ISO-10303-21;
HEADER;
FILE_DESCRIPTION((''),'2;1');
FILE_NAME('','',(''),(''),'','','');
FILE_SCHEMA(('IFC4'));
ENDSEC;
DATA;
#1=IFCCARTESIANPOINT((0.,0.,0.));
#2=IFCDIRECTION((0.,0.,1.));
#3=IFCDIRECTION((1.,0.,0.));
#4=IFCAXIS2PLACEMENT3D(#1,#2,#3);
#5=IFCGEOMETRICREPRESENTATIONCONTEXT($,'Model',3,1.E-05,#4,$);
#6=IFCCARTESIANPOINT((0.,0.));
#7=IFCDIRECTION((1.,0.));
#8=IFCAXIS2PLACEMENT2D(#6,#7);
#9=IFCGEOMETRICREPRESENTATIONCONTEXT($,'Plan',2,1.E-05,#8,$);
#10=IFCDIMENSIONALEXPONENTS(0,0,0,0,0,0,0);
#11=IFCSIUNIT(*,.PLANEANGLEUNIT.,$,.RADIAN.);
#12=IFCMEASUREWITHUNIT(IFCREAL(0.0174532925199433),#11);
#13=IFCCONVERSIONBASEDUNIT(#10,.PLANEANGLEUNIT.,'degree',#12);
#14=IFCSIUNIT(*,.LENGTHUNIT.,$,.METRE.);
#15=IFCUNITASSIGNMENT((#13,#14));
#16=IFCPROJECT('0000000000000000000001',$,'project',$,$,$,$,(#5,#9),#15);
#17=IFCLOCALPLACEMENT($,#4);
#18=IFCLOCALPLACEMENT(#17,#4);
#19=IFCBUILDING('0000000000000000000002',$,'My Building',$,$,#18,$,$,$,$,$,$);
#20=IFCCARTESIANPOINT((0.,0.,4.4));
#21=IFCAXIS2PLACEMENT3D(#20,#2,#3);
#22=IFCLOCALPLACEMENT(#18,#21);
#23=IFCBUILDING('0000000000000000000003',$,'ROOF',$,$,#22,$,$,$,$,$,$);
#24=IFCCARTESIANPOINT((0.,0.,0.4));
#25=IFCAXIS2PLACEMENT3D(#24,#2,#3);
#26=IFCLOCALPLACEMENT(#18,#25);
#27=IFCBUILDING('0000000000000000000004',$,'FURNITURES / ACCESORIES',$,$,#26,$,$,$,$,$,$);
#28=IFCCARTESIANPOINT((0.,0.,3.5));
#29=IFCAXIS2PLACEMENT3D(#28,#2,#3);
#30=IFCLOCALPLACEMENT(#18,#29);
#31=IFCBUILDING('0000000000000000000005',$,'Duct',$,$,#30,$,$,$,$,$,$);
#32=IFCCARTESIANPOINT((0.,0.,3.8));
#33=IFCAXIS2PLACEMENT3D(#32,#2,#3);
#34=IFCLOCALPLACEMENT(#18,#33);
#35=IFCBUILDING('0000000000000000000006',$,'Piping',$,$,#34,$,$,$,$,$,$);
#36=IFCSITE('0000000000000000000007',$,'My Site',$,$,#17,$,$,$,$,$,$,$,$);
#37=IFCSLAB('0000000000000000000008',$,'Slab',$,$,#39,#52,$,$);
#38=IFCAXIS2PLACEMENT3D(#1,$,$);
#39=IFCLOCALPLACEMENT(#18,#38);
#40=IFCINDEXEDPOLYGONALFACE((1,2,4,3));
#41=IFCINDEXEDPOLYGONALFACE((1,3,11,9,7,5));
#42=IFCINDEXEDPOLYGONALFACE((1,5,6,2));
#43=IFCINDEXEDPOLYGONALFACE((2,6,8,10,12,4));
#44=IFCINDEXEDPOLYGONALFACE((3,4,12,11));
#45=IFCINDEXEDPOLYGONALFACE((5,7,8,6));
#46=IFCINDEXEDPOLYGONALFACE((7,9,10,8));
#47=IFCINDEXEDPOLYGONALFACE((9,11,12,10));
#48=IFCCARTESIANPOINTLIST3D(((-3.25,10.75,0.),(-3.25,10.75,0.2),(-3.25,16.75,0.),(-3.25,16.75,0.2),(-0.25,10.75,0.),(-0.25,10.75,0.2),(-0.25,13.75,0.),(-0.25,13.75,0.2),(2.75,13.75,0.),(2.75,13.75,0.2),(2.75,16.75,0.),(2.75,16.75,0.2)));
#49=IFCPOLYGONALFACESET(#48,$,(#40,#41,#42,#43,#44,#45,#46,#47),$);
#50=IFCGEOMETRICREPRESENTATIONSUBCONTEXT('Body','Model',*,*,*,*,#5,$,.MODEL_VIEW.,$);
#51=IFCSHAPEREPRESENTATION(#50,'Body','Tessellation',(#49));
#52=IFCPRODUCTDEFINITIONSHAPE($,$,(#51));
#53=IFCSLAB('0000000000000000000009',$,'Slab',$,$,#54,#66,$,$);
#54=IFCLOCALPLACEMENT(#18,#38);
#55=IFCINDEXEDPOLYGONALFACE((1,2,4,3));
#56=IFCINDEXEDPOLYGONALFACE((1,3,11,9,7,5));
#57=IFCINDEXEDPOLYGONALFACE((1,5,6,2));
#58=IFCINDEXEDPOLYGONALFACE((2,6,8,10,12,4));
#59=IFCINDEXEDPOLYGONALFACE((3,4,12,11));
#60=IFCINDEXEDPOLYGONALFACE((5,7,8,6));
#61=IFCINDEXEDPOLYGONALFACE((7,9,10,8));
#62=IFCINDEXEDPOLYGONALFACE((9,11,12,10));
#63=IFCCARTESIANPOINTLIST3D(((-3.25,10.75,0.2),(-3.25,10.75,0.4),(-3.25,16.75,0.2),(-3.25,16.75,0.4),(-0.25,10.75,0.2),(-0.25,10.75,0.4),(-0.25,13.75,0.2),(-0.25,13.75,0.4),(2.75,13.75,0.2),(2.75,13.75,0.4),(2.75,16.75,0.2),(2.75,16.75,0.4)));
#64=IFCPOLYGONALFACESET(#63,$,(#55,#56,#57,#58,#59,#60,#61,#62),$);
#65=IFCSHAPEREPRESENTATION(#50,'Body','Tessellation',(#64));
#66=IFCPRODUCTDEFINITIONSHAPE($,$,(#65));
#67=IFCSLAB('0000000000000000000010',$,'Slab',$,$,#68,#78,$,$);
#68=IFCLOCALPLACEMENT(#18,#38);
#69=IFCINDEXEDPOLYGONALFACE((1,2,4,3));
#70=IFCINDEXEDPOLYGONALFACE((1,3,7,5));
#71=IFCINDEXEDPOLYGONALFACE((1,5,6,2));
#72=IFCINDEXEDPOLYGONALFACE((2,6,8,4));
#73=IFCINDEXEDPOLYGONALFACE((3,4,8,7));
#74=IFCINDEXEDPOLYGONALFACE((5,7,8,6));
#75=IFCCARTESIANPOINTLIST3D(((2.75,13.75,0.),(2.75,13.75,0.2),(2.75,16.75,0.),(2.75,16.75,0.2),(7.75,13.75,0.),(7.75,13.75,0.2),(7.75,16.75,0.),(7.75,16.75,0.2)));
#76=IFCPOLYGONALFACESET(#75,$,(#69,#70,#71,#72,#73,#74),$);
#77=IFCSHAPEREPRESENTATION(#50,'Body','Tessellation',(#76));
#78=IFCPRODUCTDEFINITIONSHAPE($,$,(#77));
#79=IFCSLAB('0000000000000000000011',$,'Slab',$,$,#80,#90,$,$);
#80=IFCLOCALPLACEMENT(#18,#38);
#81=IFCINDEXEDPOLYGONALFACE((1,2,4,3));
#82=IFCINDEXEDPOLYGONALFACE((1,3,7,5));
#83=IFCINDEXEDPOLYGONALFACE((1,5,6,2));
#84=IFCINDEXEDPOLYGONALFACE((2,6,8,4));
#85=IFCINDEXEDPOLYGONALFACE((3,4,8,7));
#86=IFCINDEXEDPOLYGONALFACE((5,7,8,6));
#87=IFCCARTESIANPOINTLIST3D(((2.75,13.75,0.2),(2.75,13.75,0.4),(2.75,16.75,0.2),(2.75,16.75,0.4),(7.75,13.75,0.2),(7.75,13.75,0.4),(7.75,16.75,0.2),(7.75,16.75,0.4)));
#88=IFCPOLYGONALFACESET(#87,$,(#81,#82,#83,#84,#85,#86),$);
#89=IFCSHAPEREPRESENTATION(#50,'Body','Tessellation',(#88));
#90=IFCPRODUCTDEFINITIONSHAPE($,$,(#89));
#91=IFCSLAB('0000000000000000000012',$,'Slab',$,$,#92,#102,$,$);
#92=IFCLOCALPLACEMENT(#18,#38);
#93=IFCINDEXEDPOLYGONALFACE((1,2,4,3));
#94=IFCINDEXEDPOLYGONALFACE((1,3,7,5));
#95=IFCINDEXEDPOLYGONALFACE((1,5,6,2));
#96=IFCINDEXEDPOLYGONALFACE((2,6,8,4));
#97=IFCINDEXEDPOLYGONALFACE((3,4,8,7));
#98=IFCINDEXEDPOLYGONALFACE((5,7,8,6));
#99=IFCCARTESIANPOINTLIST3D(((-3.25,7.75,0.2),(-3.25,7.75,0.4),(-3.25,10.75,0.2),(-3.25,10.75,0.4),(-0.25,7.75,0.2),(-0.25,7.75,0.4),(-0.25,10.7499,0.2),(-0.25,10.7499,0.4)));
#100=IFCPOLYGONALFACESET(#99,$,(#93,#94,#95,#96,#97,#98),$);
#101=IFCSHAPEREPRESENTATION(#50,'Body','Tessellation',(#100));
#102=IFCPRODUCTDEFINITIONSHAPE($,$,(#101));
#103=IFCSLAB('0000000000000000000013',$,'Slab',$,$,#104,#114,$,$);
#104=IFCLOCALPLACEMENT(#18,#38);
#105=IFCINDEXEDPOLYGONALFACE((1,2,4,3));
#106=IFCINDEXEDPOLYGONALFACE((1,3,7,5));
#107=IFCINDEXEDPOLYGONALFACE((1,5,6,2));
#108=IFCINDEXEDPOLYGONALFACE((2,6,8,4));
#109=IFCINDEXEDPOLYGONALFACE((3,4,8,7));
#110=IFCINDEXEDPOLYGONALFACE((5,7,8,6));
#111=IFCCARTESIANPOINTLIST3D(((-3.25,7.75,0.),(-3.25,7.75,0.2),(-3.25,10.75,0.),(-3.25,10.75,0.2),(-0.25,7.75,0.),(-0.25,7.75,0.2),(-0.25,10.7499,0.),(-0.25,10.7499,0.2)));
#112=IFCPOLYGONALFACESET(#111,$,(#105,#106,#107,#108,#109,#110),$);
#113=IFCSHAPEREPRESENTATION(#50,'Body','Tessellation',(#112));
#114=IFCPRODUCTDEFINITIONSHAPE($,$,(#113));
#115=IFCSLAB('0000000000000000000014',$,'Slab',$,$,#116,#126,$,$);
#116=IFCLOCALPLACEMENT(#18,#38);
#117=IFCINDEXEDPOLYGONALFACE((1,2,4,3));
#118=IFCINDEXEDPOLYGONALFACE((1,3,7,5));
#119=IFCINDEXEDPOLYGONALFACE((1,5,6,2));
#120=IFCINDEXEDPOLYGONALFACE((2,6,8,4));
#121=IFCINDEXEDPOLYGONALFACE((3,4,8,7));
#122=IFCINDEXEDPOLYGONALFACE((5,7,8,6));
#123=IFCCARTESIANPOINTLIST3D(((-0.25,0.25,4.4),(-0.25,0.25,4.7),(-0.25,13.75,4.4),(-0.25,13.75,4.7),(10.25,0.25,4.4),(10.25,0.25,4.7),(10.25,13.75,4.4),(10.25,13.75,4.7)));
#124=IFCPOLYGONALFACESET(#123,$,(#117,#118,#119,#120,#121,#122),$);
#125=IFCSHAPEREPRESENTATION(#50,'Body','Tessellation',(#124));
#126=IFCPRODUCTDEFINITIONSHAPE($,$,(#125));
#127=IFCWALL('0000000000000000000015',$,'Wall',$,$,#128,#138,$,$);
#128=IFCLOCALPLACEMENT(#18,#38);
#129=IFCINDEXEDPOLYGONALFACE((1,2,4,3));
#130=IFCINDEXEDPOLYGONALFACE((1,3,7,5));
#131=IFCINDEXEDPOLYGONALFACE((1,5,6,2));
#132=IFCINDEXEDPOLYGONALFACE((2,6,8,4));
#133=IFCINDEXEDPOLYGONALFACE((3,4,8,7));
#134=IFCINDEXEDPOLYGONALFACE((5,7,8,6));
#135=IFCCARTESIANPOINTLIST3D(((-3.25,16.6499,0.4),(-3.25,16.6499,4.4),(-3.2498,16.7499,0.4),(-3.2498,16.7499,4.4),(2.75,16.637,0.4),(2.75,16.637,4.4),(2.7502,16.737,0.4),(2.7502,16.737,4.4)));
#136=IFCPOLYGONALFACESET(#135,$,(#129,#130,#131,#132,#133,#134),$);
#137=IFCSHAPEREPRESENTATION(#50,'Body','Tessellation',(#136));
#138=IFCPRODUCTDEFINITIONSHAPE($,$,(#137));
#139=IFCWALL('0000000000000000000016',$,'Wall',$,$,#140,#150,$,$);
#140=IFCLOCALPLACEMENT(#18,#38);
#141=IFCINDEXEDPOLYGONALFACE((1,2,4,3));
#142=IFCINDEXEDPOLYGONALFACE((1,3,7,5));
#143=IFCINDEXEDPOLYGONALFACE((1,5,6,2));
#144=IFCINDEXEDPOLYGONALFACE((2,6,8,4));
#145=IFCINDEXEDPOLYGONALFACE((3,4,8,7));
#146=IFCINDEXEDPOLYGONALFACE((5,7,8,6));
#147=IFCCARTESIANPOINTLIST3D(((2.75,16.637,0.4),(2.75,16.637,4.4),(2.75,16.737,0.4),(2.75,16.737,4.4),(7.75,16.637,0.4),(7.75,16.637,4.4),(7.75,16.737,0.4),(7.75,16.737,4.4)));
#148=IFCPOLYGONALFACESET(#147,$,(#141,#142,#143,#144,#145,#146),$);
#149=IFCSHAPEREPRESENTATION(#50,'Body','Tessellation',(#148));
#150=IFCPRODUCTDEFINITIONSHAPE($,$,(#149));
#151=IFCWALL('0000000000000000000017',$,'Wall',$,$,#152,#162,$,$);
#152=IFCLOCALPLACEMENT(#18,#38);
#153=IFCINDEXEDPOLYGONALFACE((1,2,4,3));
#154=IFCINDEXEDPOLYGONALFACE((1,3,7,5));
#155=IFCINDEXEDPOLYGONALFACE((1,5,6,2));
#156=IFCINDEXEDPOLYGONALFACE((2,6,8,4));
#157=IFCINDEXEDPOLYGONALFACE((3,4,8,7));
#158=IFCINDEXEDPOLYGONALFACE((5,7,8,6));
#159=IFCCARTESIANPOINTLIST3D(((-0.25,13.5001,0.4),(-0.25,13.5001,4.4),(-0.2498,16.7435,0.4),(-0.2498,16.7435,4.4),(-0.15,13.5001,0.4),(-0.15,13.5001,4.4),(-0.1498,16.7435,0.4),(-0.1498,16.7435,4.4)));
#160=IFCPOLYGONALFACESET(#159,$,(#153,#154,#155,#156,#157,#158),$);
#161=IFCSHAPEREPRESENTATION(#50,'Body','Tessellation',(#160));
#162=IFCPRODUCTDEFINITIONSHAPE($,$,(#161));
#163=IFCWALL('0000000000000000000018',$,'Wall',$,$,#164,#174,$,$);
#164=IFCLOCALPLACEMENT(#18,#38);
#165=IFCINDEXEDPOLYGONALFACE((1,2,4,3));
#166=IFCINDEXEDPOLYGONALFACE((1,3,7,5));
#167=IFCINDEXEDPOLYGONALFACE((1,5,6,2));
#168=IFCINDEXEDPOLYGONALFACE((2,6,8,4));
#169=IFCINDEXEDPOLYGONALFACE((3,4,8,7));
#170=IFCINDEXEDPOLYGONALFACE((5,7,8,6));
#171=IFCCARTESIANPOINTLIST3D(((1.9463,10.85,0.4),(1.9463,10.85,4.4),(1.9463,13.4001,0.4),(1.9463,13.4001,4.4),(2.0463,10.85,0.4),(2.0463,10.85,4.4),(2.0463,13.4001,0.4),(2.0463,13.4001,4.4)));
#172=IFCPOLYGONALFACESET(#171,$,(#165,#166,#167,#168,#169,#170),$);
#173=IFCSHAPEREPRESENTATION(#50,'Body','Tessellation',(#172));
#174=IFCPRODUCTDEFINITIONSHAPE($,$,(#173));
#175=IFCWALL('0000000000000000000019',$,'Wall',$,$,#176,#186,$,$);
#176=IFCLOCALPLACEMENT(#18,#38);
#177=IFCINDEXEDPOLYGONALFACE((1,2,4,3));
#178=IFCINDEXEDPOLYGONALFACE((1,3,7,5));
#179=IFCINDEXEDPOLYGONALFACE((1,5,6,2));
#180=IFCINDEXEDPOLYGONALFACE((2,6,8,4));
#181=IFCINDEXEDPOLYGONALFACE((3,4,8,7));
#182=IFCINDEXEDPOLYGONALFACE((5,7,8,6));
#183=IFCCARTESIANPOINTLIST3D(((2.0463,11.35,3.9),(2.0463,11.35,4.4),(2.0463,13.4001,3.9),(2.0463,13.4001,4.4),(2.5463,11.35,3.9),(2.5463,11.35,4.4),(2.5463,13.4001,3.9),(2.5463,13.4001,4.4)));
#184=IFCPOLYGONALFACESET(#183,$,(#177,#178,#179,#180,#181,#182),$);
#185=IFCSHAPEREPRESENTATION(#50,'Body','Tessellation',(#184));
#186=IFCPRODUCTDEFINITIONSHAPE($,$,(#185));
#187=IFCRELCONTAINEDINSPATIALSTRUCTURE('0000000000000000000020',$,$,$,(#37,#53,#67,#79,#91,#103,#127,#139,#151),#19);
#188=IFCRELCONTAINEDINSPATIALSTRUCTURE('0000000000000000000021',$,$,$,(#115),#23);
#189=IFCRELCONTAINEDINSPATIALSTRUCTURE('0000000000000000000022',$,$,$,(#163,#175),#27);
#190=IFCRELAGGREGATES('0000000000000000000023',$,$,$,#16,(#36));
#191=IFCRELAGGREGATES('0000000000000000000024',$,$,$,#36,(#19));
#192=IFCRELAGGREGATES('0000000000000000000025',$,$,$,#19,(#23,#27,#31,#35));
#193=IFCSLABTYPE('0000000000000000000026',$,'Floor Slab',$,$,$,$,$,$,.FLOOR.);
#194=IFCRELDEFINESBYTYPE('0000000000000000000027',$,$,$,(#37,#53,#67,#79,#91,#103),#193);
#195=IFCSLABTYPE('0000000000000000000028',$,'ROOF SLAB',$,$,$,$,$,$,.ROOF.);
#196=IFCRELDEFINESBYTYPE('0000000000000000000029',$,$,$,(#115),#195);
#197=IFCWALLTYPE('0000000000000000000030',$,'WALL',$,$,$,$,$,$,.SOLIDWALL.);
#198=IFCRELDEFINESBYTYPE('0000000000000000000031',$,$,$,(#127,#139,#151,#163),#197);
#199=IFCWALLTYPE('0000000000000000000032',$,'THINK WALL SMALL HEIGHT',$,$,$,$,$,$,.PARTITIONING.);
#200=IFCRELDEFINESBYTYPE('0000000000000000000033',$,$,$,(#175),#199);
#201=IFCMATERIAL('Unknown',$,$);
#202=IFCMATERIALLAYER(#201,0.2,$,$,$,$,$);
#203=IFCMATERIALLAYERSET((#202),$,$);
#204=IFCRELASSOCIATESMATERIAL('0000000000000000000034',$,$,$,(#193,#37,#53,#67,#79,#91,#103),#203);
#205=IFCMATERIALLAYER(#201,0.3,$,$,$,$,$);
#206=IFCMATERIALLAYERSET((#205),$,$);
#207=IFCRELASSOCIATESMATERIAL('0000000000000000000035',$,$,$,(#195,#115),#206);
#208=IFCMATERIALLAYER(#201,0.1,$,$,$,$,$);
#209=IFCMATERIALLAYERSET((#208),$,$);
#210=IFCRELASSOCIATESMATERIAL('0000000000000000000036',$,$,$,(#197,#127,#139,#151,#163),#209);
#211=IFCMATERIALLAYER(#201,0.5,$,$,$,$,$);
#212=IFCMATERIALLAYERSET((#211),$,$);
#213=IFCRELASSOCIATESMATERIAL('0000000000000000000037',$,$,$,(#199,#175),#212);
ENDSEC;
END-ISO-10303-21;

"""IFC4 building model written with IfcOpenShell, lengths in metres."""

from ifc_helpers import new_model, entity, si_unit, converted_unit, frame, origin_with_axes, origin_2d_with_axis, place, context, subcontext, project, spatial, line, indexed_curve, outline, extrude, material, layer, layer_set, layer_usage, type_object, element, save


model = new_model("IFC4")

# Units and contexts
model_context = context("Model", 3, precision=1e-05, world=origin_with_axes())
plan_context = context("Plan", 2, precision=1e-05, world=origin_2d_with_axis())
body_context_1 = subcontext(model_context, "Body", "Model", "MODEL_VIEW")
ifc_project = project(units=[converted_unit("PLANEANGLEUNIT", "degree", entity("IfcReal", 0.0174532925199433), si_unit("PLANEANGLEUNIT", "RADIAN"), dimensions=[0, 0, 0, 0, 0, 0, 0]), si_unit("LENGTHUNIT", "METRE")], contexts=[model_context, plan_context])

# Site, building
site_placement = place(None, origin_with_axes())
site = spatial("IfcSite", under=ifc_project, at=site_placement, Name="My Site")
building_1_placement = place(site_placement, origin_with_axes())
building_1 = spatial("IfcBuilding", under=site, at=building_1_placement, Name="My Building")

# Slabs
ifc_material = material(Name="Unknown")
ifc_layer_1 = layer(ifc_material, 0.2)
ifc_layer_set_1 = layer_set([ifc_layer_1])
ifc_layer_usage_1 = layer_usage(ifc_layer_set_1, "AXIS3", "POSITIVE", 0.0)
slab_type_1 = type_object("IfcSlabType", Name="Floor Slab", PredefinedType="FLOOR", material=ifc_layer_set_1)
slab_1_placement = place(building_1_placement, frame((-0.25, 13.75, 0.0), z_axis=(0.0, 0.0, 1.0), x_axis=(1.0, 0.0, 0.0)))
element("IfcSlab", 1, at=slab_1_placement, inside=building_1, type_object=slab_type_1, material=ifc_layer_usage_1, Name="Slab", context=body_context_1, shape_type="SweptSolid", body=[
    extrude(outline(indexed_curve([(0.0, 0.0), (3.0, 0.0), (3.0, 3.0), (-3.0, 3.0), (-3.0, -3.0), (0.0, -3.0), (0.0, 0.0)])), None, (0.0, 0.0, 1.0), 0.2),
])
ifc_layer_usage_2 = layer_usage(ifc_layer_set_1, "AXIS3", "POSITIVE", 0.0)
slab_2_placement = place(building_1_placement, frame((-0.25, 13.75, 0.2), z_axis=(0.0, 0.0, 1.0), x_axis=(1.0, 0.0, 0.0)))
element("IfcSlab", 2, at=slab_2_placement, inside=building_1, type_object=slab_type_1, material=ifc_layer_usage_2, Name="Slab", context=body_context_1, shape_type="SweptSolid", body=[
    extrude(outline(indexed_curve([(0.0, 0.0), (3.0, 0.0), (3.0, 3.0), (-3.0, 3.0), (-3.0, -3.0), (0.0, -3.0), (0.0, 0.0)])), None, (0.0, 0.0, 1.0), 0.2),
])
ifc_layer_usage_3 = layer_usage(ifc_layer_set_1, "AXIS3", "POSITIVE", 0.0)
slab_3_placement = place(building_1_placement, frame((2.75, 16.75, 0.0), z_axis=(0.0, 0.0, 1.0), x_axis=(1.0, 0.0, 0.0)))
element("IfcSlab", 3, at=slab_3_placement, inside=building_1, type_object=slab_type_1, material=ifc_layer_usage_3, Name="Slab", context=body_context_1, shape_type="SweptSolid", body=[
    extrude(outline(indexed_curve([(0.0, 0.0), (5.0, 0.0), (5.0, -3.0), (0.0, -3.0), (0.0, 0.0)])), None, (0.0, 0.0, 1.0), 0.2),
])
ifc_layer_usage_4 = layer_usage(ifc_layer_set_1, "AXIS3", "POSITIVE", 0.0)
slab_4_placement = place(building_1_placement, frame((2.75, 16.75, 0.2), z_axis=(0.0, 0.0, 1.0), x_axis=(1.0, 0.0, 0.0)))
element("IfcSlab", 4, at=slab_4_placement, inside=building_1, type_object=slab_type_1, material=ifc_layer_usage_4, Name="Slab", context=body_context_1, shape_type="SweptSolid", body=[
    extrude(outline(indexed_curve([(0.0, 0.0), (5.0, 0.0), (5.0, -3.0), (0.0, -3.0), (0.0, 0.0)])), None, (0.0, 0.0, 1.0), 0.2),
])
ifc_layer_usage_5 = layer_usage(ifc_layer_set_1, "AXIS3", "POSITIVE", -0.2)
slab_5_placement = place(building_1_placement, frame((-3.25, 10.75, 0.4), z_axis=(0.0, 0.0, 1.0), x_axis=(1.0, 0.0, 0.0)))
element("IfcSlab", 5, at=slab_5_placement, inside=building_1, type_object=slab_type_1, material=ifc_layer_usage_5, Name="Slab", context=body_context_1, shape_type="SweptSolid", body=[
    extrude(outline(indexed_curve([(0.0, 0.0), (0.0, -3.0), (3.0, -3.0), (3.0, -0.0001), (0.0, 0.0)])), frame((0.0, 0.0, -0.2), z_axis=(0.0, 0.0, 1.0), x_axis=(1.0, 0.0, 0.0)), (0.0, 0.0, 1.0), 0.2),
])
ifc_layer_usage_6 = layer_usage(ifc_layer_set_1, "AXIS3", "POSITIVE", -0.2)
slab_6_placement = place(building_1_placement, frame((-3.25, 10.75, 0.2), z_axis=(0.0, 0.0, 1.0), x_axis=(1.0, 0.0, 0.0)))
element("IfcSlab", 6, at=slab_6_placement, inside=building_1, type_object=slab_type_1, material=ifc_layer_usage_6, Name="Slab", context=body_context_1, shape_type="SweptSolid", body=[
    extrude(outline(indexed_curve([(0.0, 0.0), (0.0, -3.0), (3.0, -3.0), (3.0, -0.0001), (0.0, 0.0)])), frame((0.0, 0.0, -0.2), z_axis=(0.0, 0.0, 1.0), x_axis=(1.0, 0.0, 0.0)), (0.0, 0.0, 1.0), 0.2),
])

# Shared definitions
building_2_placement = place(building_1_placement, frame((0.0, 0.0, 4.4), z_axis=(0.0, 0.0, 1.0), x_axis=(1.0, 0.0, 0.0)))
building_2 = spatial("IfcBuilding", under=building_1, at=building_2_placement, Name="ROOF")

# Slab
ifc_layer_2 = layer(ifc_material, 0.3)
ifc_layer_set_2 = layer_set([ifc_layer_2])
ifc_layer_usage_7 = layer_usage(ifc_layer_set_2, "AXIS3", "POSITIVE", 0.0)
slab_type_2 = type_object("IfcSlabType", Name="ROOF SLAB", PredefinedType="ROOF", material=ifc_layer_set_2)
slab_7_placement = place(building_2_placement, frame((-0.25, 13.75, 0.0), z_axis=(0.0, 0.0, 1.0), x_axis=(1.0, 0.0, 0.0)))
element("IfcSlab", 7, at=slab_7_placement, inside=building_2, type_object=slab_type_2, material=ifc_layer_usage_7, Name="Slab", context=body_context_1, shape_type="SweptSolid", body=[
    extrude(outline(indexed_curve([(0.0, 0.0), (10.5, 0.0), (10.5, -13.5), (0.0, -13.5), (0.0, 0.0)])), None, (0.0, 0.0, 1.0), 0.3),
])

# Walls
ifc_layer_3 = layer(ifc_material, 0.1)
ifc_layer_set_3 = layer_set([ifc_layer_3])
ifc_layer_usage_8 = layer_usage(ifc_layer_set_3, "AXIS2", "POSITIVE", 0.0)
wall_type_1 = type_object("IfcWallType", Name="WALL", PredefinedType="SOLIDWALL", material=ifc_layer_set_3)
wall_1_placement = place(building_1_placement, frame((-3.25, 16.6499, 0.4), z_axis=(0.0, 0.0, 1.0), x_axis=(0.999998, -0.002154, 0.0)))
element("IfcWall", 8, at=wall_1_placement, inside=building_1, type_object=wall_type_1, material=ifc_layer_usage_8, Name="Wall", context=body_context_1, shape_type="SweptSolid", body=[
    extrude(outline(indexed_curve([(0.0, 0.0), (0.0, 0.1), (6.0, 0.1), (6.0, 0.0)], segments=[line(1, 2, 3, 4, 1)])), origin_with_axes(), (0.0, 0.0, 1.0), 4.0),
])
ifc_layer_usage_9 = layer_usage(ifc_layer_set_3, "AXIS2", "POSITIVE", 0.0)
wall_2_placement = place(building_1_placement, frame((2.75, 16.637, 0.4), z_axis=(0.0, 0.0, 1.0), x_axis=(1.0, 0.0, 0.0)))
element("IfcWall", 9, at=wall_2_placement, inside=building_1, type_object=wall_type_1, material=ifc_layer_usage_9, Name="Wall", context=body_context_1, shape_type="SweptSolid", body=[
    extrude(outline(indexed_curve([(0.0, 0.0), (0.0, 0.1), (5.0, 0.1), (5.0, 0.0)], segments=[line(1, 2, 3, 4, 1)])), origin_with_axes(), (0.0, 0.0, 1.0), 4.0),
])
ifc_layer_usage_10 = layer_usage(ifc_layer_set_3, "AXIS2", "POSITIVE", 0.0)
wall_3_placement = place(building_1_placement, frame((-0.15, 13.5001, 0.4), z_axis=(0.0, 0.0, 1.0), x_axis=(0.000067, 1.0, 0.0)))
element("IfcWall", 10, at=wall_3_placement, inside=building_1, type_object=wall_type_1, material=ifc_layer_usage_10, Name="Wall", context=body_context_1, shape_type="SweptSolid", body=[
    extrude(outline(indexed_curve([(0.0, 0.0), (0.0, 0.1), (3.2434, 0.1), (3.2434, 0.0)], segments=[line(1, 2, 3, 4, 1)])), origin_with_axes(), (0.0, 0.0, 1.0), 4.0),
])

# Shared definitions
building_3_placement = place(building_1_placement, frame((0.0, 0.0, 0.4), z_axis=(0.0, 0.0, 1.0), x_axis=(1.0, 0.0, 0.0)))
building_3 = spatial("IfcBuilding", under=building_1, at=building_3_placement, Name="FURNITURES / ACCESORIES")

# Wall
ifc_layer_usage_11 = layer_usage(ifc_layer_set_3, "AXIS2", "POSITIVE", 0.0)
wall_4_placement = place(building_3_placement, frame((1.9463, 13.4001, 0.0), z_axis=(0.0, 0.0, 1.0), x_axis=(0.0, -1.0, 0.0)))
element("IfcWall", 11, at=wall_4_placement, inside=building_3, type_object=wall_type_1, material=ifc_layer_usage_11, Name="Wall", context=body_context_1, shape_type="SweptSolid", body=[
    extrude(outline(indexed_curve([(0.0, 0.0), (0.0, 0.1), (2.5501, 0.1), (2.5501, 0.0)], segments=[line(1, 2, 3, 4, 1)])), origin_with_axes(), (0.0, 0.0, 1.0), 4.0),
])

# Wall
ifc_layer_4 = layer(ifc_material, 0.5)
ifc_layer_set_4 = layer_set([ifc_layer_4])
ifc_layer_usage_12 = layer_usage(ifc_layer_set_4, "AXIS2", "POSITIVE", 0.0)
wall_type_2 = type_object("IfcWallType", Name="THINK WALL SMALL HEIGHT", PredefinedType="PARTITIONING", material=ifc_layer_set_4)
wall_5_placement = place(building_3_placement, frame((2.5463, 11.35, 3.5), z_axis=(0.0, 0.0, 1.0), x_axis=(0.000008, 1.0, 0.0)))
element("IfcWall", 12, at=wall_5_placement, inside=building_3, type_object=wall_type_2, material=ifc_layer_usage_12, Name="Wall", context=body_context_1, shape_type="SweptSolid", body=[
    extrude(outline(indexed_curve([(0.0, 0.0), (0.0, 0.5), (2.0501, 0.5), (2.0501, 0.0)], segments=[line(1, 2, 3, 4, 1)])), origin_with_axes(), (0.0, 0.0, 1.0), 0.5),
])

# Shared definitions
building_4_placement = place(building_1_placement, frame((0.0, 0.0, 3.5), z_axis=(0.0, 0.0, 1.0), x_axis=(1.0, 0.0, 0.0)))
building_4 = spatial("IfcBuilding", under=building_1, at=building_4_placement, Name="Duct")

# Shared definitions
building_5_placement = place(building_1_placement, frame((0.0, 0.0, 3.8), z_axis=(0.0, 0.0, 1.0), x_axis=(1.0, 0.0, 0.0)))
building_5 = spatial("IfcBuilding", under=building_1, at=building_5_placement, Name="Piping")

save(model, "model.ifc")
